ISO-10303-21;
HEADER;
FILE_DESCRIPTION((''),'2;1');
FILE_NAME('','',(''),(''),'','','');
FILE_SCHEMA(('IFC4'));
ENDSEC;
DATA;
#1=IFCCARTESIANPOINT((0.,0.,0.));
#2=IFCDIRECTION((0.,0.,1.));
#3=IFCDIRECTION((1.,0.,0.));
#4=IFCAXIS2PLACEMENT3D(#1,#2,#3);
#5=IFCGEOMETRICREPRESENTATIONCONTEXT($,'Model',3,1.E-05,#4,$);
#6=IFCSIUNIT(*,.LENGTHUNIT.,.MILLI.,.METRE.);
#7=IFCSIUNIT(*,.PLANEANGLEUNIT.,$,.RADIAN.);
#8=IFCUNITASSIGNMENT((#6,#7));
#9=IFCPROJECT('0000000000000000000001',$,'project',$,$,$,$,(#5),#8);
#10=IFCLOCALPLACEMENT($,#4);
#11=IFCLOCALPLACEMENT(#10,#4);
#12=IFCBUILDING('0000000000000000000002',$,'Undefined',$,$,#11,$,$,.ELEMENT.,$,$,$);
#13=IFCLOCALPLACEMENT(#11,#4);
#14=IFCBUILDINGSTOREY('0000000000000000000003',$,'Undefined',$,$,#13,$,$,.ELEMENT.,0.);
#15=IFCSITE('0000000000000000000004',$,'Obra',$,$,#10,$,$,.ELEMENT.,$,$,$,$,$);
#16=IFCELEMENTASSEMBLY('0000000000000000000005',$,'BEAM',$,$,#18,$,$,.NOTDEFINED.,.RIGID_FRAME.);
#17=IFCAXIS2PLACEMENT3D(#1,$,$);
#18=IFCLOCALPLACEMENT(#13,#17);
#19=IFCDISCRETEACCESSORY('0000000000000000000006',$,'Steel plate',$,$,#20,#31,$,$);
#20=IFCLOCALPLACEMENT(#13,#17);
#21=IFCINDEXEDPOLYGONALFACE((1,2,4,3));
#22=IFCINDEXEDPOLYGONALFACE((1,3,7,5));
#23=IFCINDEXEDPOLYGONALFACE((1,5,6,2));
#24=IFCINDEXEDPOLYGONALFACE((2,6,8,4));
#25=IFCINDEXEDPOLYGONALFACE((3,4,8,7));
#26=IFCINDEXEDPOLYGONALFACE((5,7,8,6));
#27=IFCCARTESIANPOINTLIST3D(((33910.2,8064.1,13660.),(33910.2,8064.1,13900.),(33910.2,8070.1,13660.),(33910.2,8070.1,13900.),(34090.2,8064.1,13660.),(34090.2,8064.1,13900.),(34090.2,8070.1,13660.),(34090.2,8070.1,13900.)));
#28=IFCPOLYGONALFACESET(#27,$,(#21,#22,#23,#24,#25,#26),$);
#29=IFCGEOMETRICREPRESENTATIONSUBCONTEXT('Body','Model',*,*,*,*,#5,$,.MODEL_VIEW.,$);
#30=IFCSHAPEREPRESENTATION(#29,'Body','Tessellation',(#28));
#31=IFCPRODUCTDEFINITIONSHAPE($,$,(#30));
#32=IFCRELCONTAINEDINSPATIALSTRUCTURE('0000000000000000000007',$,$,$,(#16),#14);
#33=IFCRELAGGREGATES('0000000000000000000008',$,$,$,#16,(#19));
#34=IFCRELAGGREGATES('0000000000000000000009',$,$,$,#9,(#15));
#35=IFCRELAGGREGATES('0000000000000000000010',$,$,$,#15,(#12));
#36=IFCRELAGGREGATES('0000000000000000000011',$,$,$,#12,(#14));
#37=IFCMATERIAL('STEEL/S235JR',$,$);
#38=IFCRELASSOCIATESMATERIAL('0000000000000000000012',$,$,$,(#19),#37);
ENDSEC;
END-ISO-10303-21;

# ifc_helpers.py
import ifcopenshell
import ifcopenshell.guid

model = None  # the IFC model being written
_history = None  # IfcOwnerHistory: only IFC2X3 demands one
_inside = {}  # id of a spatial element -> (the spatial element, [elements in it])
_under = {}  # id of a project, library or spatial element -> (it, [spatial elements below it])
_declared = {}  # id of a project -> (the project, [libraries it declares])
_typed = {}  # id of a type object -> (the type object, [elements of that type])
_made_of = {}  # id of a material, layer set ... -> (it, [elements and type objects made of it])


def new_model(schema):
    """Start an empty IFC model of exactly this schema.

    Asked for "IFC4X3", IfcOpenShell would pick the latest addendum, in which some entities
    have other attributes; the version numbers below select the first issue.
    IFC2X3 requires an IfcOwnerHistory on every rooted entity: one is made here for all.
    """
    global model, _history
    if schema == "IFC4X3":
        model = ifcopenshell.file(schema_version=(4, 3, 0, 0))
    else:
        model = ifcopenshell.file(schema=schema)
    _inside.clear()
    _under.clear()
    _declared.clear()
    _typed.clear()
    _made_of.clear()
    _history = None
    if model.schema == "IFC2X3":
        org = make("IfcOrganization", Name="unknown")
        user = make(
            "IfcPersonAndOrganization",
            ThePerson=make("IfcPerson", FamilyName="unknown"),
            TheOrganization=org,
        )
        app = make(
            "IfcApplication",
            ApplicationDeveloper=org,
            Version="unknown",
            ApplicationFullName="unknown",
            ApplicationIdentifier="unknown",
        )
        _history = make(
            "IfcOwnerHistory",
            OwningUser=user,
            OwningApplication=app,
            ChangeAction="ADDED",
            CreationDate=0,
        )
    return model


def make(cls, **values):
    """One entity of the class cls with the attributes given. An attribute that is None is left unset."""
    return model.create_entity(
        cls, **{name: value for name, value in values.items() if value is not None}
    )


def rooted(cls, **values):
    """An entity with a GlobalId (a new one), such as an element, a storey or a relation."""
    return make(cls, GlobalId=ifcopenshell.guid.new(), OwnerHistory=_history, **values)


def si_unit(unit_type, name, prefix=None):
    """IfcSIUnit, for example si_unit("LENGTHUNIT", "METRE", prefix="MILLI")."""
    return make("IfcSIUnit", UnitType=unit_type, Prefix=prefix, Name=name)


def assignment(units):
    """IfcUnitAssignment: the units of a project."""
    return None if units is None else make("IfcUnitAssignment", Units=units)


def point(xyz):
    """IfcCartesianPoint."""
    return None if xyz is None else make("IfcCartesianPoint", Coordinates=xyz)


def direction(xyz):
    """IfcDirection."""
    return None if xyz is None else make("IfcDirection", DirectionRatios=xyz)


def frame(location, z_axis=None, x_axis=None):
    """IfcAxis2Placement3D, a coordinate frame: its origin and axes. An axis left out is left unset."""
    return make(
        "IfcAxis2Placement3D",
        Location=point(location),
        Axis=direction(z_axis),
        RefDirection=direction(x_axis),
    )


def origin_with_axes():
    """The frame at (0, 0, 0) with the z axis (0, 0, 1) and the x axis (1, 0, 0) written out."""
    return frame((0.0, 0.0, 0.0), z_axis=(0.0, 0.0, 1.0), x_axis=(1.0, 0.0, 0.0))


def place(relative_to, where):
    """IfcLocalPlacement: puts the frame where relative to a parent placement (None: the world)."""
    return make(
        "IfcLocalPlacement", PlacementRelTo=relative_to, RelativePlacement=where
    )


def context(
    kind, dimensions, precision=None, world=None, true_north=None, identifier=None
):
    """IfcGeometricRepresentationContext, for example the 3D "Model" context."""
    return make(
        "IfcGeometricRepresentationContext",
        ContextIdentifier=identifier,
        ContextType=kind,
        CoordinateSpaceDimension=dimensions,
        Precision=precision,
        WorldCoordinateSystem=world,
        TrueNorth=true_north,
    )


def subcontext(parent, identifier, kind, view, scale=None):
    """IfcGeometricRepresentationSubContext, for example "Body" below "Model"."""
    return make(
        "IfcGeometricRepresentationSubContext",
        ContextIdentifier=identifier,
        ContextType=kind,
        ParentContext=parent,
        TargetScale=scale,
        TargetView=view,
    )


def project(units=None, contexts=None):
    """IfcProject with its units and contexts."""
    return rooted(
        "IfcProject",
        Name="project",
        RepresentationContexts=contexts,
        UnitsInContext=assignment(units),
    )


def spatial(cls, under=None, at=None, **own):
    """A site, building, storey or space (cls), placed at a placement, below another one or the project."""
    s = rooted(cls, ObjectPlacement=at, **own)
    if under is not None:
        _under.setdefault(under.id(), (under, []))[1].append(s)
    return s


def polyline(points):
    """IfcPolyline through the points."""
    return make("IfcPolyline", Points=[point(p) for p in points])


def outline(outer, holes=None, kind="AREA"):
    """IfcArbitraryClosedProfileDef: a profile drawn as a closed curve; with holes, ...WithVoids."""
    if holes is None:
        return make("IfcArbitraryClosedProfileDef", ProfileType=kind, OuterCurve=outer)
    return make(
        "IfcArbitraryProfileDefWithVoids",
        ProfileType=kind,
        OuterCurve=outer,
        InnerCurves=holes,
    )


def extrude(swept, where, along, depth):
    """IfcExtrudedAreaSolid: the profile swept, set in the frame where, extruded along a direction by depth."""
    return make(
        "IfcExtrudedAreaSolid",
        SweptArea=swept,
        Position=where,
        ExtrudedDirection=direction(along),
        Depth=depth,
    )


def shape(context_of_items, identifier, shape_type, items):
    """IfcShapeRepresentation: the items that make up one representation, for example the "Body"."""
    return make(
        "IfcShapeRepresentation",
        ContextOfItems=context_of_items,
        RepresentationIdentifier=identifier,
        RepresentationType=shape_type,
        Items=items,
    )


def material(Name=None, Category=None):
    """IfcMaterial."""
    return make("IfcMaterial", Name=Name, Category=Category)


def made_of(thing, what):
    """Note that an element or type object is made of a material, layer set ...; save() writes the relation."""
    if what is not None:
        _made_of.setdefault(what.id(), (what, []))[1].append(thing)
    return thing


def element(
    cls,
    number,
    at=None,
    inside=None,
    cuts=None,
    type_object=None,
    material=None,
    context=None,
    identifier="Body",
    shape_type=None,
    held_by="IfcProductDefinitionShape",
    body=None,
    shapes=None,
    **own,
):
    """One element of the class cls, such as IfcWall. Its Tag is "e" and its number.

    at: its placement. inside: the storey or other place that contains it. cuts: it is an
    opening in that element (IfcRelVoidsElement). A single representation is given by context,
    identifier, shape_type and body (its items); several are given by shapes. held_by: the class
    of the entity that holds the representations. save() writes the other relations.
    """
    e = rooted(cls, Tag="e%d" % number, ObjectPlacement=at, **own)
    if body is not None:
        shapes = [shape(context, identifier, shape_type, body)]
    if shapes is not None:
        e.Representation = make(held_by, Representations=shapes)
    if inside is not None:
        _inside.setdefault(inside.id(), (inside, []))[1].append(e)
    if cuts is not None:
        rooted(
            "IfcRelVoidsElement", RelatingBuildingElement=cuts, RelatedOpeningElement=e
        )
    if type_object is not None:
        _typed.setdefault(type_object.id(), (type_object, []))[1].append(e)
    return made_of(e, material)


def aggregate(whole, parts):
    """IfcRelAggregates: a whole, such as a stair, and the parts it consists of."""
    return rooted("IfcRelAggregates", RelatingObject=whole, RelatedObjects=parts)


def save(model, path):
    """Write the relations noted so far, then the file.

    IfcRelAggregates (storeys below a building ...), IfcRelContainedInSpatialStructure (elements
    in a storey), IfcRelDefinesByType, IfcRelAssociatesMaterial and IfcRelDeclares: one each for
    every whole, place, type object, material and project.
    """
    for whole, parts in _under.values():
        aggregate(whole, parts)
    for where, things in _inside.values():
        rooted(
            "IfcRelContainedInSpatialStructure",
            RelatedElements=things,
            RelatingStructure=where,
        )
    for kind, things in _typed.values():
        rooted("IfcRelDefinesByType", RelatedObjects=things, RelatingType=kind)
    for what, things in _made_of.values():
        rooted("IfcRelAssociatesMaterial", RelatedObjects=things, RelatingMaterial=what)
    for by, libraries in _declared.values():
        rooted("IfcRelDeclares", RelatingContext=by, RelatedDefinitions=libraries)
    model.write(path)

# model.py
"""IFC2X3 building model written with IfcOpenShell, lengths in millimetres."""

from ifc_helpers import new_model, si_unit, frame, origin_with_axes, place, context, subcontext, project, spatial, polyline, outline, extrude, material, element, aggregate, save


model = new_model("IFC2X3")

# Units and contexts
model_context = context("Model", 3, precision=1e-05, world=origin_with_axes())
body_context = subcontext(model_context, "Body", "Model", "MODEL_VIEW")
ifc_project = project(units=[si_unit("LENGTHUNIT", "METRE", prefix="MILLI"), si_unit("PLANEANGLEUNIT", "RADIAN")], contexts=[model_context])

# Site, building, storey
site_placement = place(None, origin_with_axes())
site = spatial("IfcSite", under=ifc_project, at=site_placement, Name="Obra", CompositionType="ELEMENT")
building_placement = place(site_placement, origin_with_axes())
building = spatial("IfcBuilding", under=site, at=building_placement, Name="Undefined", CompositionType="ELEMENT")
storey_placement = place(building_placement, origin_with_axes())
storey = spatial("IfcBuildingStorey", under=building, at=storey_placement, Name="Undefined", CompositionType="ELEMENT", Elevation=0.0)

# Shared definitions
ifc_material_1 = material(Name="STEEL/S235JR")

# Element assembly
assembly_1_placement = place(storey_placement, origin_with_axes())
assembly_1 = element("IfcElementAssembly", 1, at=assembly_1_placement, inside=storey, Name="BEAM", AssemblyPlace="NOTDEFINED", PredefinedType="RIGID_FRAME")

# Discrete accessory
discrete_accessory_1_placement = place(assembly_1_placement, frame((34090.2, 8067.1, 13900.0), z_axis=(-0.000033, -1.0, 0.0), x_axis=(-1.0, 0.000033, 0.0)))
discrete_accessory_1 = element("IfcDiscreteAccessory", 2, at=discrete_accessory_1_placement, material=ifc_material_1, Name="Steel plate", context=body_context, shape_type="SweptSolid", body=[
    extrude(outline(polyline([(0.0, 0.0), (180.0, 0.0), (180.0, 240.0), (0.0, 240.0), (0.0, 0.0)])), frame((0.0, 0.0, -3.0), z_axis=(0.0, 0.0, 1.0), x_axis=(1.0, 0.0, 0.0)), (0.0, 0.0, 1.0), 6.0),
])
aggregate(assembly_1, [discrete_accessory_1])

save(model, "model.ifc")
